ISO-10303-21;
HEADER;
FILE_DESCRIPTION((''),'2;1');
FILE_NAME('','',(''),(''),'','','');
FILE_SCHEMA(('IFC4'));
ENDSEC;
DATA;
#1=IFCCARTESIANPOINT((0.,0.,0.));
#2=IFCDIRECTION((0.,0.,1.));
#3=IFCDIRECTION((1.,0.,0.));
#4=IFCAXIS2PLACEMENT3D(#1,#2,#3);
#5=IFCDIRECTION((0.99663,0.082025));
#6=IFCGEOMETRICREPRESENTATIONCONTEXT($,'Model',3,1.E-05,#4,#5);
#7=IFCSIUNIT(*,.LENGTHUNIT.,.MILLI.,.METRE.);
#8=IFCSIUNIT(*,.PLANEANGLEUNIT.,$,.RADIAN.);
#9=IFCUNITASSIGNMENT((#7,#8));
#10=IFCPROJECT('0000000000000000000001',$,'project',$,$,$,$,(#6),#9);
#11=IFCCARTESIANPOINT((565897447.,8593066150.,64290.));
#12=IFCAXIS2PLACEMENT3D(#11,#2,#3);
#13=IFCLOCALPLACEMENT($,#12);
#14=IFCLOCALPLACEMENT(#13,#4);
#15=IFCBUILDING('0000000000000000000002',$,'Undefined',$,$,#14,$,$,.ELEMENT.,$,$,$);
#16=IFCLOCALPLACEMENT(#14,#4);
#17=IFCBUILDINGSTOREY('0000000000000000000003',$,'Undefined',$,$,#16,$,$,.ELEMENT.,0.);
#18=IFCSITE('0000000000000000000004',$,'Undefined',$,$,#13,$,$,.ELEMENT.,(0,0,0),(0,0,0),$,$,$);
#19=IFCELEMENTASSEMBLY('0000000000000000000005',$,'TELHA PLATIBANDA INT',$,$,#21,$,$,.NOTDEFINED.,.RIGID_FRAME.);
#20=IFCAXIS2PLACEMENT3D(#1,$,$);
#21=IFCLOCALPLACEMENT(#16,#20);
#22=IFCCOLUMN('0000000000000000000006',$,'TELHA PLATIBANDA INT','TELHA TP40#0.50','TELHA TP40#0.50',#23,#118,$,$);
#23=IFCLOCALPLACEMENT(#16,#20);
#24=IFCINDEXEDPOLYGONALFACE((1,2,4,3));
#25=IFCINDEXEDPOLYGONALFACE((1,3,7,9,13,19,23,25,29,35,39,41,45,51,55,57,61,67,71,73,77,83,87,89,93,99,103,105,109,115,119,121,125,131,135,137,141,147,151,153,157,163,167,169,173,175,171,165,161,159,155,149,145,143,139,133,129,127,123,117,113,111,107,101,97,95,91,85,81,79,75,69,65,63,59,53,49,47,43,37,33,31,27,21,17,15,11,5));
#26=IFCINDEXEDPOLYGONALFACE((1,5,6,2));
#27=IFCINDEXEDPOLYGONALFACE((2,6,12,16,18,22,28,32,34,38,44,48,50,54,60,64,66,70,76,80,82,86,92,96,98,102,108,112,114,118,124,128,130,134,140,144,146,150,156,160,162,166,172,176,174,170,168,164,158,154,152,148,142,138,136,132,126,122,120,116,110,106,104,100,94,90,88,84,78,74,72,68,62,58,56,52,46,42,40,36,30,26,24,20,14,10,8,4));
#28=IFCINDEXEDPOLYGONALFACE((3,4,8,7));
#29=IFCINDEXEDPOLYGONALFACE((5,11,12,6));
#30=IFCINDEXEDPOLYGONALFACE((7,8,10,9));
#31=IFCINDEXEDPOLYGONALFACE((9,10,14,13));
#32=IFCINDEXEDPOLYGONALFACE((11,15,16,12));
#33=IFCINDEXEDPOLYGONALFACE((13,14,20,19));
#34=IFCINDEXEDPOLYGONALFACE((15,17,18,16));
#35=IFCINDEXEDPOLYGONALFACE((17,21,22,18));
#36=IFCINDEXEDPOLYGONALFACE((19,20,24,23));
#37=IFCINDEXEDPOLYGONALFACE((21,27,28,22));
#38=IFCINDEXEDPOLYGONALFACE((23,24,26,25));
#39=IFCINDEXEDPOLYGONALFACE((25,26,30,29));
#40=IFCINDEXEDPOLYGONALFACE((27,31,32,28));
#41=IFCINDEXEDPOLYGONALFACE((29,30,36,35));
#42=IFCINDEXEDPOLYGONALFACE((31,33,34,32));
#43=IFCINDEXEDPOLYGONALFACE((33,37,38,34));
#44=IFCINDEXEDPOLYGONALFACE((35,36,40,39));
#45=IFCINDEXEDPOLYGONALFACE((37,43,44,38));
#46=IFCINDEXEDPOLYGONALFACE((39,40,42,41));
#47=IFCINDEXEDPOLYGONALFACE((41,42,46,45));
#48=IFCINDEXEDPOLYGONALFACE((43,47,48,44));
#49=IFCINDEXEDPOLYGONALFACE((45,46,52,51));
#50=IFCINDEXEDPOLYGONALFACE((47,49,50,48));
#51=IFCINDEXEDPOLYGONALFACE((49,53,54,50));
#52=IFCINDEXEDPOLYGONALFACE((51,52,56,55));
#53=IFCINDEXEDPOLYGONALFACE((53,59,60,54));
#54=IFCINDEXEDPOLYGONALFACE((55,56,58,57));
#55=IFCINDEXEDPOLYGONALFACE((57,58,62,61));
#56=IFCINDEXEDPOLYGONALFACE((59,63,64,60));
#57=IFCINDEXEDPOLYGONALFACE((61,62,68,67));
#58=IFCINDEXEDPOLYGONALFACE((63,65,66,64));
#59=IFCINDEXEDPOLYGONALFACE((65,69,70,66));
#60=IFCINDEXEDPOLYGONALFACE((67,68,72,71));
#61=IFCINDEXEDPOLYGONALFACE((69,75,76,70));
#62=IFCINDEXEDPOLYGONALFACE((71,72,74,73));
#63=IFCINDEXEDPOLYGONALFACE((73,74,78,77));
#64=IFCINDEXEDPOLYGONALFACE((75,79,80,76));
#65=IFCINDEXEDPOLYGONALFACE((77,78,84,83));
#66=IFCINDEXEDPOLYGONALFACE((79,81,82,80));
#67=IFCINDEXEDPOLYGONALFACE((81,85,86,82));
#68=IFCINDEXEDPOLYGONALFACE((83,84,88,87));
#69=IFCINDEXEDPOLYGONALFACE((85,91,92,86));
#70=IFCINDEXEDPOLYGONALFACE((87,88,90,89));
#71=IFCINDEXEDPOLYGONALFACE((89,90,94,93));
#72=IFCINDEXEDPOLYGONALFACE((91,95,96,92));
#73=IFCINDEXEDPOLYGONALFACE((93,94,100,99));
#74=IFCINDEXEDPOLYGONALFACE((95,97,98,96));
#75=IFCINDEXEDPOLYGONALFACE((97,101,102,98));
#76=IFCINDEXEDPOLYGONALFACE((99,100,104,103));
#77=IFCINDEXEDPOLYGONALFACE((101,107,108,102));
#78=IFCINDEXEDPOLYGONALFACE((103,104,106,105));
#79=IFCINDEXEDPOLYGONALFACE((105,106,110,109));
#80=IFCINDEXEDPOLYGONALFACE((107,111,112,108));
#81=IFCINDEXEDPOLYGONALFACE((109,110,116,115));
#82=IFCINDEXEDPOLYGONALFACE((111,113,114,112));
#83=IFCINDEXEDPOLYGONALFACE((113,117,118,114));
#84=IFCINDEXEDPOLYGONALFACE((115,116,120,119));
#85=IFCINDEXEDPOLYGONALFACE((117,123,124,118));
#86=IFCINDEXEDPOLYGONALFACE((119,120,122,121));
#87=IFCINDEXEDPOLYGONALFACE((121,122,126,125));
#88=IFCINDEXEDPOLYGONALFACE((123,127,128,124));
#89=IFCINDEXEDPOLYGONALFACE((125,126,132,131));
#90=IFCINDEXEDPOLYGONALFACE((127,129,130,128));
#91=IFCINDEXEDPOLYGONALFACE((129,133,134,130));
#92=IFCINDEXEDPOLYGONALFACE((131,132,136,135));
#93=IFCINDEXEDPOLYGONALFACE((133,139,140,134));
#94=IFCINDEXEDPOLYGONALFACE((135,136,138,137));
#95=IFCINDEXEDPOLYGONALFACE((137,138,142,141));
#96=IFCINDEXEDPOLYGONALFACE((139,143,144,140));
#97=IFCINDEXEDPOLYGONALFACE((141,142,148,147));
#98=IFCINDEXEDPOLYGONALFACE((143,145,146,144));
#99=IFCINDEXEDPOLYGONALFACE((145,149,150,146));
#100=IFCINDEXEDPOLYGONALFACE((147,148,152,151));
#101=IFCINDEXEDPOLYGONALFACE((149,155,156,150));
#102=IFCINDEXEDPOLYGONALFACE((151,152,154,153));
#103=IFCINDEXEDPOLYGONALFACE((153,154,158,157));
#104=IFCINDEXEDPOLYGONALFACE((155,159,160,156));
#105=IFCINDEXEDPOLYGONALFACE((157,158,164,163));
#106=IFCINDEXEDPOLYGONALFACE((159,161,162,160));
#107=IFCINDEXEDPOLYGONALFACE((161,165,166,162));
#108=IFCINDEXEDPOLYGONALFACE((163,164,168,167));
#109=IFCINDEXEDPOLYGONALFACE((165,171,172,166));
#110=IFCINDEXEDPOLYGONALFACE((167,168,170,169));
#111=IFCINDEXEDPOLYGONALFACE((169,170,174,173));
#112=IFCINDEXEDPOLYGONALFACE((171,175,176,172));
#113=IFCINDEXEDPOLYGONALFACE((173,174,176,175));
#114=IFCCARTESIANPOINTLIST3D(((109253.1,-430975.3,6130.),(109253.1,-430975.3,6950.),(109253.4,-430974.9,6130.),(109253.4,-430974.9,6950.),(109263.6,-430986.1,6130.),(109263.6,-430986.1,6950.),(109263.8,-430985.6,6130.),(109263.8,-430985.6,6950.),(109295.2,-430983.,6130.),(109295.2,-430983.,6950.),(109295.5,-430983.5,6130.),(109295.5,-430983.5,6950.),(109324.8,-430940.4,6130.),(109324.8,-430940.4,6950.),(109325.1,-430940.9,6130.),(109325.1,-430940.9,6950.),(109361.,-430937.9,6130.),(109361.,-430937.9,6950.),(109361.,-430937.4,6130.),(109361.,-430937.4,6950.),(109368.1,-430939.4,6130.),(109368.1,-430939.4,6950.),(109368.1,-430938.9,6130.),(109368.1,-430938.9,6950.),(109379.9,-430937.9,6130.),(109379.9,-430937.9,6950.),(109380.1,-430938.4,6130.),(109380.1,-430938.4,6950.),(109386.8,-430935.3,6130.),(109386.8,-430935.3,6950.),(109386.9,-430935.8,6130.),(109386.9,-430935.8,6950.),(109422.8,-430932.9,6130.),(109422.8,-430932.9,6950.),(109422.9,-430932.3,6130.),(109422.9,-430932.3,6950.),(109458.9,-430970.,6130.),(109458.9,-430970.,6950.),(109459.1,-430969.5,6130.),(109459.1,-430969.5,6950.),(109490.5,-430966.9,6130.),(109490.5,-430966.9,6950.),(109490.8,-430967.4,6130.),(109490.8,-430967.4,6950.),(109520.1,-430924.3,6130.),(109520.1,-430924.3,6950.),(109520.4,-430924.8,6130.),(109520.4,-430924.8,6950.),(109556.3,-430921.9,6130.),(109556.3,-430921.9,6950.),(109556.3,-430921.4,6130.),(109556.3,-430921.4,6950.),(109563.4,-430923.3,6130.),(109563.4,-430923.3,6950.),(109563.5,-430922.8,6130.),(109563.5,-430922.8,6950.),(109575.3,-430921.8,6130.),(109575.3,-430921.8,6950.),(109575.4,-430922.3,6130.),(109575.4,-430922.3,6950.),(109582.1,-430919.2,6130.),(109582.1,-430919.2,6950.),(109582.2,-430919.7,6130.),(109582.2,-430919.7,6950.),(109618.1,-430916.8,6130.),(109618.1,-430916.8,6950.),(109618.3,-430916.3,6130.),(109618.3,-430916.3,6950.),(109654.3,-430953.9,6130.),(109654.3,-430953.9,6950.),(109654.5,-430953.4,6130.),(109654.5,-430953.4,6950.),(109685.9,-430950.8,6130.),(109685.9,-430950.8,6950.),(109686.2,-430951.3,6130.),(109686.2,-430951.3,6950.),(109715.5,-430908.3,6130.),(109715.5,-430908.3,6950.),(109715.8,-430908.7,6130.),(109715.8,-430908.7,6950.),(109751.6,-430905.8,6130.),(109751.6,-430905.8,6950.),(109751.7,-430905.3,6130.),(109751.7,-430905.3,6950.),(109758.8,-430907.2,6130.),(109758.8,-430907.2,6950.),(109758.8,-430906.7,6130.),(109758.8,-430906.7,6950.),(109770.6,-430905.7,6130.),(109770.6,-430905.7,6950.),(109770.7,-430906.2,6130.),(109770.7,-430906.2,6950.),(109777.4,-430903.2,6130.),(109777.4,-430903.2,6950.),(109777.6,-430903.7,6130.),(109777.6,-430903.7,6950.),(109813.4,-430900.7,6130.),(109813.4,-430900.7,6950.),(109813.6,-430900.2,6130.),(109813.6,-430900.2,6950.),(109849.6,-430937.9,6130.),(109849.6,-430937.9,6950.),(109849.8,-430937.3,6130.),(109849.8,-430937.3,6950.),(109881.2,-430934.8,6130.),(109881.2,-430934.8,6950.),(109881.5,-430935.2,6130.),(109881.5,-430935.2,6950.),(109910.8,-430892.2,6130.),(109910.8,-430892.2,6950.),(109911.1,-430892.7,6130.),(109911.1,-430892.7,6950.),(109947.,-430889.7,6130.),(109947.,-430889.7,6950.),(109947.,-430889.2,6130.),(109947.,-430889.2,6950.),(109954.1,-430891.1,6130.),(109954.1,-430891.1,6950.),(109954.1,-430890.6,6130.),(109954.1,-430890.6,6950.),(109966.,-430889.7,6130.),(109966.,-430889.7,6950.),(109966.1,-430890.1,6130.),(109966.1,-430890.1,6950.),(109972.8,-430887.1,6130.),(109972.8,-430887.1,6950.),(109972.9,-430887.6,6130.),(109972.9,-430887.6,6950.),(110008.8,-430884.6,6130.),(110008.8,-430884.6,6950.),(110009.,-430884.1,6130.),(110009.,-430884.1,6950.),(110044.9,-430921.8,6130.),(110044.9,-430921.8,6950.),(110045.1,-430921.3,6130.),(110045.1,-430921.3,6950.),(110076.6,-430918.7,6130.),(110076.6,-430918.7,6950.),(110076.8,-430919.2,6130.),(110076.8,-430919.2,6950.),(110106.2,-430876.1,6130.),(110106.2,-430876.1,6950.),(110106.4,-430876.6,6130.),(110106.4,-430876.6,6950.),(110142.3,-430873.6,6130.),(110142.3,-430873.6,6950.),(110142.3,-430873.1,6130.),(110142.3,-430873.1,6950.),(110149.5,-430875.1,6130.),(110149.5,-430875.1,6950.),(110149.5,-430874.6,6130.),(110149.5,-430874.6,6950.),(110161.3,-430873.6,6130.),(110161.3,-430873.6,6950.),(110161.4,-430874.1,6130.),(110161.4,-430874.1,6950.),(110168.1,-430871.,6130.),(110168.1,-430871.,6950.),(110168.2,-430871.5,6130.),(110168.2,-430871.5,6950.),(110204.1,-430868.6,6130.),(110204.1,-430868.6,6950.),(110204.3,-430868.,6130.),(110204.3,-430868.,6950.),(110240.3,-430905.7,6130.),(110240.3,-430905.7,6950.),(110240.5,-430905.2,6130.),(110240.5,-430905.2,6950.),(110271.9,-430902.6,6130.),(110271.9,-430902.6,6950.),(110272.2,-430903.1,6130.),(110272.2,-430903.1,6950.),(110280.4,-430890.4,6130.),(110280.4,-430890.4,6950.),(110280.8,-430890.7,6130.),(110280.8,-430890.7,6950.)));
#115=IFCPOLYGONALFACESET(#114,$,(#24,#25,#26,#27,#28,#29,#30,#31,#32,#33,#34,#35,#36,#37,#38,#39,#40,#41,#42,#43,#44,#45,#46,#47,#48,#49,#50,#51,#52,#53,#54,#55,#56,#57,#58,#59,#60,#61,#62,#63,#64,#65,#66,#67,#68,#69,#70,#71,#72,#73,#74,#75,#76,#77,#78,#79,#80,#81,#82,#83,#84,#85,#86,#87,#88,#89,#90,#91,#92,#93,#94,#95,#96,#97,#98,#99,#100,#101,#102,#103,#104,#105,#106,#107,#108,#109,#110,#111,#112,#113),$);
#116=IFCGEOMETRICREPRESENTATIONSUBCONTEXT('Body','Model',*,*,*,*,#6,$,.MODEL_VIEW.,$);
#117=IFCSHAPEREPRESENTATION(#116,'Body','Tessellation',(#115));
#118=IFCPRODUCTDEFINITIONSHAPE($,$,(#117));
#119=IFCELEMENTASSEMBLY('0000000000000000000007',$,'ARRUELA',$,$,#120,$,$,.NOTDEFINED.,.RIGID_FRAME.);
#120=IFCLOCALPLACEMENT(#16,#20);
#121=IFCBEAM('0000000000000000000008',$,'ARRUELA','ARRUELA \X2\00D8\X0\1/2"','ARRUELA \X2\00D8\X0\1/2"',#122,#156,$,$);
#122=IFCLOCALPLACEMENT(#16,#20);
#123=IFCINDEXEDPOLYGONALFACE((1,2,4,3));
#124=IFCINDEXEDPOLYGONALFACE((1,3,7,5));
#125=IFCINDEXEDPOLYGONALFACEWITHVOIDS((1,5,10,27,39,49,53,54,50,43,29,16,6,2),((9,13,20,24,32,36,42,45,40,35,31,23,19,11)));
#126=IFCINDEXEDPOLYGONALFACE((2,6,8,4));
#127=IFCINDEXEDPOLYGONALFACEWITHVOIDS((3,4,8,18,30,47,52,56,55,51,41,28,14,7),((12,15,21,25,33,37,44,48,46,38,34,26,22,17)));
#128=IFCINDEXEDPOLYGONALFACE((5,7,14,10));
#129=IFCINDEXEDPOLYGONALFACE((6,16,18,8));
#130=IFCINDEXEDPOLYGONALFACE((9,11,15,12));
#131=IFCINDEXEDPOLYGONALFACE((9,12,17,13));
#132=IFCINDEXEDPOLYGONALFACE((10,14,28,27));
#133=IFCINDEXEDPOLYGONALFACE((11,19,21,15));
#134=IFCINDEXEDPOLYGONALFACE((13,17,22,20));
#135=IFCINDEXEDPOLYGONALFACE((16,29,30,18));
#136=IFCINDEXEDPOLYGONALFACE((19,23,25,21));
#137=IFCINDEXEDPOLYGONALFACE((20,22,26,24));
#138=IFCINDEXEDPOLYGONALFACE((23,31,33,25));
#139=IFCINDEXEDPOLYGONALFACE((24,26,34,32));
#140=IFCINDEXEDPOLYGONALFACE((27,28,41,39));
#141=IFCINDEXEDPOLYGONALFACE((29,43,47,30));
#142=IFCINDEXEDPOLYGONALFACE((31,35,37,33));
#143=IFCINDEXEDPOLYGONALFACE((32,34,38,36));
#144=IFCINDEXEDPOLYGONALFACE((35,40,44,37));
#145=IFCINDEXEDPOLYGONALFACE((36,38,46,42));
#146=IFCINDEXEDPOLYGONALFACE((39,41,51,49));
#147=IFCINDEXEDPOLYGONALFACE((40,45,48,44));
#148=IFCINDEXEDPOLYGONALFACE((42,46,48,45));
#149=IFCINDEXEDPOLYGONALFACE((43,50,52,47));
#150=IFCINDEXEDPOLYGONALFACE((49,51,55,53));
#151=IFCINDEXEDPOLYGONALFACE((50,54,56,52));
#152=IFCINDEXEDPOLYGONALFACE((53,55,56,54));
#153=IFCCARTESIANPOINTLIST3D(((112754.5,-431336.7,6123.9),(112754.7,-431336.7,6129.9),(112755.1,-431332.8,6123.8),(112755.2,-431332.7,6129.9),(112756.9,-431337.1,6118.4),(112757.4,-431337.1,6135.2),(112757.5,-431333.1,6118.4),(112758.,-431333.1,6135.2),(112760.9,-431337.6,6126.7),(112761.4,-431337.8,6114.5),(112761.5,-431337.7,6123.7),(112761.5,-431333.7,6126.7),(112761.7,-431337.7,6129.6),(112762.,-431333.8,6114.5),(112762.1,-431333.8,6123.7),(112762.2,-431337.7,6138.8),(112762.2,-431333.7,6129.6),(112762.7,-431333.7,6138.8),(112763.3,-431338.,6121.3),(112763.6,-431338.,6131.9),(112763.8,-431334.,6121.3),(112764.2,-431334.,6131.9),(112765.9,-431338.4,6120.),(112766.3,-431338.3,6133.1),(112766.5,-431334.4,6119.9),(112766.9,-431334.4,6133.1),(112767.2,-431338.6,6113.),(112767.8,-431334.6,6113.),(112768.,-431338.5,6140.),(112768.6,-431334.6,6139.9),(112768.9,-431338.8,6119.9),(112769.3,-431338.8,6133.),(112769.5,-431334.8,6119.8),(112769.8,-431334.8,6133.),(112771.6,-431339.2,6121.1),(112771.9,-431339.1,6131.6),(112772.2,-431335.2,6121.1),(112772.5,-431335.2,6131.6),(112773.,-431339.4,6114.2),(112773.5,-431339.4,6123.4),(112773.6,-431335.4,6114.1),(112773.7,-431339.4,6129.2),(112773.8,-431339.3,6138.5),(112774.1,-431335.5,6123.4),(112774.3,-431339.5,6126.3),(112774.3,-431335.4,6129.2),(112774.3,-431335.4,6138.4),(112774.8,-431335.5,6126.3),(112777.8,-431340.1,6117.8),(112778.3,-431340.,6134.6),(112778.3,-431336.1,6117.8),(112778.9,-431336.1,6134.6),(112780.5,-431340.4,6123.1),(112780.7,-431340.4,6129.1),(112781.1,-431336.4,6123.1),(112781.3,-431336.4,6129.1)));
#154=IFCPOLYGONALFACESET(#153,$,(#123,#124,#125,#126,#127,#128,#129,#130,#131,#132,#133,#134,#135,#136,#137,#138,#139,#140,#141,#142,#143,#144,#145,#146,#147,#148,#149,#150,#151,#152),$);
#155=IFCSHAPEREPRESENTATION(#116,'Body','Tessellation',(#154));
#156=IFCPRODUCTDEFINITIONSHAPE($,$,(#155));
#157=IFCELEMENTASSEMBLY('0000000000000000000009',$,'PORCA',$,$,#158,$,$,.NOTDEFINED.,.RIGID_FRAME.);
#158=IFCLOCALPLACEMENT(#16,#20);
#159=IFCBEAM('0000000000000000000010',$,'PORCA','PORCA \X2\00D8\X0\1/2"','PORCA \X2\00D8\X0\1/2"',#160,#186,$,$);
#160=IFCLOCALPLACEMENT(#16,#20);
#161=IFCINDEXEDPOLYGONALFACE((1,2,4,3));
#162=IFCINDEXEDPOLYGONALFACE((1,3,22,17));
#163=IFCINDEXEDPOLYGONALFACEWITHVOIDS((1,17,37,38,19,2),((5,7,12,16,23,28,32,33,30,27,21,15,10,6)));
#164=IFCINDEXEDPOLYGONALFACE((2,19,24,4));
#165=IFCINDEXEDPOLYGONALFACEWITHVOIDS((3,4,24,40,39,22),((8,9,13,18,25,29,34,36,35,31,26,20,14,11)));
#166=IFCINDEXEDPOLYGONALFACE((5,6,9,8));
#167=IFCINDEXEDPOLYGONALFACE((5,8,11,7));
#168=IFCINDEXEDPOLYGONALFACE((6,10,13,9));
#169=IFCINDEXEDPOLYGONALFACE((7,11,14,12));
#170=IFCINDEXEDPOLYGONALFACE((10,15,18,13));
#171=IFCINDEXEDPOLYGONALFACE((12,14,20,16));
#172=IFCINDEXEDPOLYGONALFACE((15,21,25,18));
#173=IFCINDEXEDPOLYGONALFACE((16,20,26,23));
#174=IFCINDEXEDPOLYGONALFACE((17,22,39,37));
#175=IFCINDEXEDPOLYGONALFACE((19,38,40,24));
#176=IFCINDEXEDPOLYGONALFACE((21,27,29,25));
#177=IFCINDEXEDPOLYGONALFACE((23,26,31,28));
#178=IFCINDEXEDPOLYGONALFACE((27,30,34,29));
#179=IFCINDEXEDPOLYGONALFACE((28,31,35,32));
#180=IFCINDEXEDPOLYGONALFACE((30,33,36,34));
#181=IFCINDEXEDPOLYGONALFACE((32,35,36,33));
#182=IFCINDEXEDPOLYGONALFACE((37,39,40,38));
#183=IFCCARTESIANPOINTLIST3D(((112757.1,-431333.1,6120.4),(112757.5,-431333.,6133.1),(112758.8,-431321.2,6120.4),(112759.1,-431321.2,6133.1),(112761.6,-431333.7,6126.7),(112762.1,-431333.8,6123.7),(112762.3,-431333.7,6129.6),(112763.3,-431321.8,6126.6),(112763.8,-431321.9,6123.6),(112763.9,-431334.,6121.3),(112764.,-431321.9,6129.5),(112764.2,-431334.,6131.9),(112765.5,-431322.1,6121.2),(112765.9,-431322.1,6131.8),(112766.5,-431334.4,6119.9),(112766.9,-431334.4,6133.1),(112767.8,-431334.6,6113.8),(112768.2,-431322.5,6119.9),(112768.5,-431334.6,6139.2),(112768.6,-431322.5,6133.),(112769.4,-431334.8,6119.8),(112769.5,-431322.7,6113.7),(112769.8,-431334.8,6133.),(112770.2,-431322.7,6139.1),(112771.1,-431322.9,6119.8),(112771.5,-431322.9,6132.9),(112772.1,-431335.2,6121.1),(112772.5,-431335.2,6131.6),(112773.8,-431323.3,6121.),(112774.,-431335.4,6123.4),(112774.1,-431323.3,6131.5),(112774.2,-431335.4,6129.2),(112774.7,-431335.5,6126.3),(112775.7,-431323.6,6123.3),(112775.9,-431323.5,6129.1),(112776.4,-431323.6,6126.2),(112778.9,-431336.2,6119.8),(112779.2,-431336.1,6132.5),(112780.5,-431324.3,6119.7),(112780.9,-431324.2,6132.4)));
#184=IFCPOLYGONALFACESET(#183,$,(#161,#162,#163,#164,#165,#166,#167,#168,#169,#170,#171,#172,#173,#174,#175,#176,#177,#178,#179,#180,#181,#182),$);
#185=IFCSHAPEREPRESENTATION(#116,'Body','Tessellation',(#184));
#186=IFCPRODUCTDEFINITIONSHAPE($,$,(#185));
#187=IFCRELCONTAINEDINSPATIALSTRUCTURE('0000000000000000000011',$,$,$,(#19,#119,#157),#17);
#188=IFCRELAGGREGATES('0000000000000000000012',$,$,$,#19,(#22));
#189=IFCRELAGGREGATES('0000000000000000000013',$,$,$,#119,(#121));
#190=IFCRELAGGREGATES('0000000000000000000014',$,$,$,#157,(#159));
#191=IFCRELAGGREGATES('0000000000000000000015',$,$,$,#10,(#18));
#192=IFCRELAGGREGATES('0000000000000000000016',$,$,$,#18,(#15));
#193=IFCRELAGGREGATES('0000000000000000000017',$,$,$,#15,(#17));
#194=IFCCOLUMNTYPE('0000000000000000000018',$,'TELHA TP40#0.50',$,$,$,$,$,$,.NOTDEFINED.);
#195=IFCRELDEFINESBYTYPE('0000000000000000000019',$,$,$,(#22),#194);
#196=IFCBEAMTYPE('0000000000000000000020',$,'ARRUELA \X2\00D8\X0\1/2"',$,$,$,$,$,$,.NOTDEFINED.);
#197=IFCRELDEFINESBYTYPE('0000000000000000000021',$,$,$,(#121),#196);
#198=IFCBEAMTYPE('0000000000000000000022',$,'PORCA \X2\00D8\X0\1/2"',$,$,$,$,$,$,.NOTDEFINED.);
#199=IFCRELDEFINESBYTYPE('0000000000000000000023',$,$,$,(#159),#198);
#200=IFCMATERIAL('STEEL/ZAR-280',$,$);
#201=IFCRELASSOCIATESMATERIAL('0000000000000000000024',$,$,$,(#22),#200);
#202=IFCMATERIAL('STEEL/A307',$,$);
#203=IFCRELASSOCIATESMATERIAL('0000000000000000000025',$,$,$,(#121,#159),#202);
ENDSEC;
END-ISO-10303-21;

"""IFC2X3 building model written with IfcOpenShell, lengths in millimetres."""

from ifc_helpers import new_model, si_unit, direction, frame, origin_with_axes, place, context, subcontext, project, spatial, polyline, outline, extrude, material, type_object, element, aggregate, save


model = new_model("IFC2X3")

# Units and contexts
model_context = context("Model", 3, precision=1e-05, world=origin_with_axes(), true_north=direction((0.99663, 0.082025)))
body_context = subcontext(model_context, "Body", "Model", "MODEL_VIEW")
ifc_project = project(units=[si_unit("LENGTHUNIT", "METRE", prefix="MILLI"), si_unit("PLANEANGLEUNIT", "RADIAN")], contexts=[model_context])

# Site, building, storey
site_placement = place(None, frame((565897447.0, 8593066150.0, 64290.0), z_axis=(0.0, 0.0, 1.0), x_axis=(1.0, 0.0, 0.0)))
site = spatial("IfcSite", under=ifc_project, at=site_placement, Name="Undefined", CompositionType="ELEMENT", RefLatitude=(0, 0, 0), RefLongitude=(0, 0, 0))
building_placement = place(site_placement, origin_with_axes())
building = spatial("IfcBuilding", under=site, at=building_placement, Name="Undefined", CompositionType="ELEMENT")
storey_placement = place(building_placement, origin_with_axes())
storey = spatial("IfcBuildingStorey", under=building, at=storey_placement, Name="Undefined", CompositionType="ELEMENT", Elevation=0.0)

# Element assembly, column
ifc_material_1 = material(Name="STEEL/ZAR-280")
column_type = type_object("IfcColumnType", Name="TELHA TP40#0.50", PredefinedType="NOTDEFINED")
assembly_1_placement = place(storey_placement, origin_with_axes())
assembly_1 = element("IfcElementAssembly", 1, at=assembly_1_placement, inside=storey, Name="TELHA PLATIBANDA INT", AssemblyPlace="NOTDEFINED", PredefinedType="RIGID_FRAME")
column_1_placement = place(assembly_1_placement, frame((109766.4, -430924.4, 6130.0), z_axis=(0.0, 0.0, 1.0), x_axis=(0.082025, -0.99663, 0.0)))
column_1 = element("IfcColumn", 2, at=column_1_placement, type_object=column_type, material=ifc_material_1, Name="TELHA PLATIBANDA INT", Description="TELHA TP40#0.50", ObjectType="TELHA TP40#0.50", context=body_context, shape_type="SweptSolid", body=[
    extrude(outline(polyline([(440.8, -19.8), (473.8, 20.2), (505.8, 20.2), (515.4, 8.6), (515.0, 8.3), (505.6, 19.8), (474.0, 19.8), (441.0, -20.2), (404.7, -20.2), (397.7, -18.2), (385.9, -18.2), (378.9, -20.2), (342.6, -20.2), (309.6, 19.8), (278.0, 19.8), (245.0, -20.2), (208.7, -20.2), (201.7, -18.2), (189.9, -18.2), (182.9, -20.2), (146.6, -20.2), (113.6, 19.8), (82.0, 19.8), (49.0, -20.2), (12.7, -20.2), (5.7, -18.2), (-6.1, -18.2), (-13.1, -20.2), (-49.4, -20.2), (-82.4, 19.8), (-114.0, 19.8), (-147.0, -20.2), (-183.3, -20.2), (-190.3, -18.2), (-202.1, -18.2), (-209.1, -20.2), (-245.4, -20.2), (-278.4, 19.8), (-310.0, 19.8), (-343.0, -20.2), (-379.3, -20.2), (-386.3, -18.2), (-398.1, -18.2), (-405.1, -20.2), (-441.4, -20.2), (-474.4, 19.8), (-506.0, 19.8), (-515.4, 8.3), (-515.8, 8.6), (-506.2, 20.2), (-474.2, 20.2), (-441.2, -19.8), (-405.2, -19.8), (-398.2, -17.8), (-386.2, -17.8), (-379.2, -19.8), (-343.2, -19.8), (-310.2, 20.2), (-278.2, 20.2), (-245.2, -19.8), (-209.2, -19.8), (-202.2, -17.8), (-190.2, -17.8), (-183.2, -19.8), (-147.2, -19.8), (-114.2, 20.2), (-82.2, 20.2), (-49.2, -19.8), (-13.2, -19.8), (-6.2, -17.8), (5.8, -17.8), (12.8, -19.8), (48.8, -19.8), (81.8, 20.2), (113.8, 20.2), (146.8, -19.8), (182.8, -19.8), (189.8, -17.8), (201.8, -17.8), (208.8, -19.8), (244.8, -19.8), (277.8, 20.2), (309.8, 20.2), (342.8, -19.8), (378.8, -19.8), (385.8, -17.8), (397.8, -17.8), (404.8, -19.8), (440.8, -19.8)])), frame((0.0, 0.0, 820.0), z_axis=(0.0, 0.0, -1.0), x_axis=(0.0, 1.0, 0.0)), (0.0, 0.0, 1.0), 820.0),
])
aggregate(assembly_1, [column_1])

# Element assemblies, beams
assembly_2_placement = place(storey_placement, origin_with_axes())
assembly_2 = element("IfcElementAssembly", 3, at=assembly_2_placement, inside=storey, Name="ARRUELA", AssemblyPlace="NOTDEFINED", PredefinedType="RIGID_FRAME")
ifc_material_2 = material(Name="STEEL/A307")
beam_type_1 = type_object("IfcBeamType", Name="ARRUELA Ø1/2\"", PredefinedType="NOTDEFINED")
beam_1_placement = place(assembly_2_placement, frame((112768.2, -431334.6, 6126.5), z_axis=(0.989733, -0.139903, -0.029248), x_axis=(-0.139769, -0.990162, 0.006615)))
beam_1 = element("IfcBeam", 4, at=beam_1_placement, type_object=beam_type_1, material=ifc_material_2, Name="ARRUELA", Description="ARRUELA Ø1/2\"", ObjectType="ARRUELA Ø1/2\"", context=body_context, shape_type="SweptSolid", body=[
    extrude(outline(polyline([(-8.4, 10.5), (-3.0, 13.2), (3.0, 13.2), (8.4, 10.5), (12.2, 5.9), (13.5, 0.0), (12.2, -5.9), (8.4, -10.5), (3.0, -13.2), (-3.0, -13.2), (-8.4, -10.5), (-12.2, -5.9), (-13.5, 0.0), (-12.2, 5.9), (-8.4, 10.5)]), holes=[polyline([(6.6, 1.5), (5.3, 4.2), (2.9, 6.1), (0.0, 6.7), (-2.9, 6.1), (-5.3, 4.2), (-6.6, 1.5), (-6.6, -1.5), (-5.3, -4.2), (-2.9, -6.1), (0.0, -6.8), (2.9, -6.1), (5.3, -4.2), (6.6, -1.5), (6.6, 1.5)])]), frame((4.0, 0.0, 0.0), z_axis=(-1.0, 0.0, 0.0), x_axis=(0.0, -1.0, 0.0)), (0.0, 0.0, 1.0), 4.0),
])
aggregate(assembly_2, [beam_1])
assembly_3_placement = place(storey_placement, origin_with_axes())
assembly_3 = element("IfcElementAssembly", 5, at=assembly_3_placement, inside=storey, Name="PORCA", AssemblyPlace="NOTDEFINED", PredefinedType="RIGID_FRAME")
beam_type_2 = type_object("IfcBeamType", Name="PORCA Ø1/2\"", PredefinedType="NOTDEFINED")
beam_2_placement = place(assembly_3_placement, frame((112769.8, -431322.7, 6126.4), z_axis=(0.989733, -0.139903, -0.029248), x_axis=(-0.139769, -0.990162, 0.006615)))
beam_2 = element("IfcBeam", 6, at=beam_2_placement, type_object=beam_type_2, material=ifc_material_2, Name="PORCA", Description="PORCA Ø1/2\"", ObjectType="PORCA Ø1/2\"", context=body_context, shape_type="SweptSolid", body=[
    extrude(outline(polyline([(12.7, 0.0), (6.3, -11.0), (-6.3, -11.0), (-12.7, 0.0), (-6.3, 11.0), (6.3, 11.0), (12.7, 0.0)]), holes=[polyline([(-5.3, -4.2), (-2.9, -6.0), (0.0, -6.7), (2.9, -6.0), (5.3, -4.2), (6.6, -1.5), (6.6, 1.5), (5.3, 4.2), (2.9, 6.0), (0.0, 6.7), (-2.9, 6.0), (-5.3, 4.2), (-6.6, 1.5), (-6.6, -1.5), (-5.3, -4.2)])]), frame((12.0, 0.0, 0.0), z_axis=(-1.0, 0.0, 0.0), x_axis=(0.0, -1.0, 0.0)), (0.0, 0.0, 1.0), 12.0),
])
aggregate(assembly_3, [beam_2])

save(model, "model.ifc")
